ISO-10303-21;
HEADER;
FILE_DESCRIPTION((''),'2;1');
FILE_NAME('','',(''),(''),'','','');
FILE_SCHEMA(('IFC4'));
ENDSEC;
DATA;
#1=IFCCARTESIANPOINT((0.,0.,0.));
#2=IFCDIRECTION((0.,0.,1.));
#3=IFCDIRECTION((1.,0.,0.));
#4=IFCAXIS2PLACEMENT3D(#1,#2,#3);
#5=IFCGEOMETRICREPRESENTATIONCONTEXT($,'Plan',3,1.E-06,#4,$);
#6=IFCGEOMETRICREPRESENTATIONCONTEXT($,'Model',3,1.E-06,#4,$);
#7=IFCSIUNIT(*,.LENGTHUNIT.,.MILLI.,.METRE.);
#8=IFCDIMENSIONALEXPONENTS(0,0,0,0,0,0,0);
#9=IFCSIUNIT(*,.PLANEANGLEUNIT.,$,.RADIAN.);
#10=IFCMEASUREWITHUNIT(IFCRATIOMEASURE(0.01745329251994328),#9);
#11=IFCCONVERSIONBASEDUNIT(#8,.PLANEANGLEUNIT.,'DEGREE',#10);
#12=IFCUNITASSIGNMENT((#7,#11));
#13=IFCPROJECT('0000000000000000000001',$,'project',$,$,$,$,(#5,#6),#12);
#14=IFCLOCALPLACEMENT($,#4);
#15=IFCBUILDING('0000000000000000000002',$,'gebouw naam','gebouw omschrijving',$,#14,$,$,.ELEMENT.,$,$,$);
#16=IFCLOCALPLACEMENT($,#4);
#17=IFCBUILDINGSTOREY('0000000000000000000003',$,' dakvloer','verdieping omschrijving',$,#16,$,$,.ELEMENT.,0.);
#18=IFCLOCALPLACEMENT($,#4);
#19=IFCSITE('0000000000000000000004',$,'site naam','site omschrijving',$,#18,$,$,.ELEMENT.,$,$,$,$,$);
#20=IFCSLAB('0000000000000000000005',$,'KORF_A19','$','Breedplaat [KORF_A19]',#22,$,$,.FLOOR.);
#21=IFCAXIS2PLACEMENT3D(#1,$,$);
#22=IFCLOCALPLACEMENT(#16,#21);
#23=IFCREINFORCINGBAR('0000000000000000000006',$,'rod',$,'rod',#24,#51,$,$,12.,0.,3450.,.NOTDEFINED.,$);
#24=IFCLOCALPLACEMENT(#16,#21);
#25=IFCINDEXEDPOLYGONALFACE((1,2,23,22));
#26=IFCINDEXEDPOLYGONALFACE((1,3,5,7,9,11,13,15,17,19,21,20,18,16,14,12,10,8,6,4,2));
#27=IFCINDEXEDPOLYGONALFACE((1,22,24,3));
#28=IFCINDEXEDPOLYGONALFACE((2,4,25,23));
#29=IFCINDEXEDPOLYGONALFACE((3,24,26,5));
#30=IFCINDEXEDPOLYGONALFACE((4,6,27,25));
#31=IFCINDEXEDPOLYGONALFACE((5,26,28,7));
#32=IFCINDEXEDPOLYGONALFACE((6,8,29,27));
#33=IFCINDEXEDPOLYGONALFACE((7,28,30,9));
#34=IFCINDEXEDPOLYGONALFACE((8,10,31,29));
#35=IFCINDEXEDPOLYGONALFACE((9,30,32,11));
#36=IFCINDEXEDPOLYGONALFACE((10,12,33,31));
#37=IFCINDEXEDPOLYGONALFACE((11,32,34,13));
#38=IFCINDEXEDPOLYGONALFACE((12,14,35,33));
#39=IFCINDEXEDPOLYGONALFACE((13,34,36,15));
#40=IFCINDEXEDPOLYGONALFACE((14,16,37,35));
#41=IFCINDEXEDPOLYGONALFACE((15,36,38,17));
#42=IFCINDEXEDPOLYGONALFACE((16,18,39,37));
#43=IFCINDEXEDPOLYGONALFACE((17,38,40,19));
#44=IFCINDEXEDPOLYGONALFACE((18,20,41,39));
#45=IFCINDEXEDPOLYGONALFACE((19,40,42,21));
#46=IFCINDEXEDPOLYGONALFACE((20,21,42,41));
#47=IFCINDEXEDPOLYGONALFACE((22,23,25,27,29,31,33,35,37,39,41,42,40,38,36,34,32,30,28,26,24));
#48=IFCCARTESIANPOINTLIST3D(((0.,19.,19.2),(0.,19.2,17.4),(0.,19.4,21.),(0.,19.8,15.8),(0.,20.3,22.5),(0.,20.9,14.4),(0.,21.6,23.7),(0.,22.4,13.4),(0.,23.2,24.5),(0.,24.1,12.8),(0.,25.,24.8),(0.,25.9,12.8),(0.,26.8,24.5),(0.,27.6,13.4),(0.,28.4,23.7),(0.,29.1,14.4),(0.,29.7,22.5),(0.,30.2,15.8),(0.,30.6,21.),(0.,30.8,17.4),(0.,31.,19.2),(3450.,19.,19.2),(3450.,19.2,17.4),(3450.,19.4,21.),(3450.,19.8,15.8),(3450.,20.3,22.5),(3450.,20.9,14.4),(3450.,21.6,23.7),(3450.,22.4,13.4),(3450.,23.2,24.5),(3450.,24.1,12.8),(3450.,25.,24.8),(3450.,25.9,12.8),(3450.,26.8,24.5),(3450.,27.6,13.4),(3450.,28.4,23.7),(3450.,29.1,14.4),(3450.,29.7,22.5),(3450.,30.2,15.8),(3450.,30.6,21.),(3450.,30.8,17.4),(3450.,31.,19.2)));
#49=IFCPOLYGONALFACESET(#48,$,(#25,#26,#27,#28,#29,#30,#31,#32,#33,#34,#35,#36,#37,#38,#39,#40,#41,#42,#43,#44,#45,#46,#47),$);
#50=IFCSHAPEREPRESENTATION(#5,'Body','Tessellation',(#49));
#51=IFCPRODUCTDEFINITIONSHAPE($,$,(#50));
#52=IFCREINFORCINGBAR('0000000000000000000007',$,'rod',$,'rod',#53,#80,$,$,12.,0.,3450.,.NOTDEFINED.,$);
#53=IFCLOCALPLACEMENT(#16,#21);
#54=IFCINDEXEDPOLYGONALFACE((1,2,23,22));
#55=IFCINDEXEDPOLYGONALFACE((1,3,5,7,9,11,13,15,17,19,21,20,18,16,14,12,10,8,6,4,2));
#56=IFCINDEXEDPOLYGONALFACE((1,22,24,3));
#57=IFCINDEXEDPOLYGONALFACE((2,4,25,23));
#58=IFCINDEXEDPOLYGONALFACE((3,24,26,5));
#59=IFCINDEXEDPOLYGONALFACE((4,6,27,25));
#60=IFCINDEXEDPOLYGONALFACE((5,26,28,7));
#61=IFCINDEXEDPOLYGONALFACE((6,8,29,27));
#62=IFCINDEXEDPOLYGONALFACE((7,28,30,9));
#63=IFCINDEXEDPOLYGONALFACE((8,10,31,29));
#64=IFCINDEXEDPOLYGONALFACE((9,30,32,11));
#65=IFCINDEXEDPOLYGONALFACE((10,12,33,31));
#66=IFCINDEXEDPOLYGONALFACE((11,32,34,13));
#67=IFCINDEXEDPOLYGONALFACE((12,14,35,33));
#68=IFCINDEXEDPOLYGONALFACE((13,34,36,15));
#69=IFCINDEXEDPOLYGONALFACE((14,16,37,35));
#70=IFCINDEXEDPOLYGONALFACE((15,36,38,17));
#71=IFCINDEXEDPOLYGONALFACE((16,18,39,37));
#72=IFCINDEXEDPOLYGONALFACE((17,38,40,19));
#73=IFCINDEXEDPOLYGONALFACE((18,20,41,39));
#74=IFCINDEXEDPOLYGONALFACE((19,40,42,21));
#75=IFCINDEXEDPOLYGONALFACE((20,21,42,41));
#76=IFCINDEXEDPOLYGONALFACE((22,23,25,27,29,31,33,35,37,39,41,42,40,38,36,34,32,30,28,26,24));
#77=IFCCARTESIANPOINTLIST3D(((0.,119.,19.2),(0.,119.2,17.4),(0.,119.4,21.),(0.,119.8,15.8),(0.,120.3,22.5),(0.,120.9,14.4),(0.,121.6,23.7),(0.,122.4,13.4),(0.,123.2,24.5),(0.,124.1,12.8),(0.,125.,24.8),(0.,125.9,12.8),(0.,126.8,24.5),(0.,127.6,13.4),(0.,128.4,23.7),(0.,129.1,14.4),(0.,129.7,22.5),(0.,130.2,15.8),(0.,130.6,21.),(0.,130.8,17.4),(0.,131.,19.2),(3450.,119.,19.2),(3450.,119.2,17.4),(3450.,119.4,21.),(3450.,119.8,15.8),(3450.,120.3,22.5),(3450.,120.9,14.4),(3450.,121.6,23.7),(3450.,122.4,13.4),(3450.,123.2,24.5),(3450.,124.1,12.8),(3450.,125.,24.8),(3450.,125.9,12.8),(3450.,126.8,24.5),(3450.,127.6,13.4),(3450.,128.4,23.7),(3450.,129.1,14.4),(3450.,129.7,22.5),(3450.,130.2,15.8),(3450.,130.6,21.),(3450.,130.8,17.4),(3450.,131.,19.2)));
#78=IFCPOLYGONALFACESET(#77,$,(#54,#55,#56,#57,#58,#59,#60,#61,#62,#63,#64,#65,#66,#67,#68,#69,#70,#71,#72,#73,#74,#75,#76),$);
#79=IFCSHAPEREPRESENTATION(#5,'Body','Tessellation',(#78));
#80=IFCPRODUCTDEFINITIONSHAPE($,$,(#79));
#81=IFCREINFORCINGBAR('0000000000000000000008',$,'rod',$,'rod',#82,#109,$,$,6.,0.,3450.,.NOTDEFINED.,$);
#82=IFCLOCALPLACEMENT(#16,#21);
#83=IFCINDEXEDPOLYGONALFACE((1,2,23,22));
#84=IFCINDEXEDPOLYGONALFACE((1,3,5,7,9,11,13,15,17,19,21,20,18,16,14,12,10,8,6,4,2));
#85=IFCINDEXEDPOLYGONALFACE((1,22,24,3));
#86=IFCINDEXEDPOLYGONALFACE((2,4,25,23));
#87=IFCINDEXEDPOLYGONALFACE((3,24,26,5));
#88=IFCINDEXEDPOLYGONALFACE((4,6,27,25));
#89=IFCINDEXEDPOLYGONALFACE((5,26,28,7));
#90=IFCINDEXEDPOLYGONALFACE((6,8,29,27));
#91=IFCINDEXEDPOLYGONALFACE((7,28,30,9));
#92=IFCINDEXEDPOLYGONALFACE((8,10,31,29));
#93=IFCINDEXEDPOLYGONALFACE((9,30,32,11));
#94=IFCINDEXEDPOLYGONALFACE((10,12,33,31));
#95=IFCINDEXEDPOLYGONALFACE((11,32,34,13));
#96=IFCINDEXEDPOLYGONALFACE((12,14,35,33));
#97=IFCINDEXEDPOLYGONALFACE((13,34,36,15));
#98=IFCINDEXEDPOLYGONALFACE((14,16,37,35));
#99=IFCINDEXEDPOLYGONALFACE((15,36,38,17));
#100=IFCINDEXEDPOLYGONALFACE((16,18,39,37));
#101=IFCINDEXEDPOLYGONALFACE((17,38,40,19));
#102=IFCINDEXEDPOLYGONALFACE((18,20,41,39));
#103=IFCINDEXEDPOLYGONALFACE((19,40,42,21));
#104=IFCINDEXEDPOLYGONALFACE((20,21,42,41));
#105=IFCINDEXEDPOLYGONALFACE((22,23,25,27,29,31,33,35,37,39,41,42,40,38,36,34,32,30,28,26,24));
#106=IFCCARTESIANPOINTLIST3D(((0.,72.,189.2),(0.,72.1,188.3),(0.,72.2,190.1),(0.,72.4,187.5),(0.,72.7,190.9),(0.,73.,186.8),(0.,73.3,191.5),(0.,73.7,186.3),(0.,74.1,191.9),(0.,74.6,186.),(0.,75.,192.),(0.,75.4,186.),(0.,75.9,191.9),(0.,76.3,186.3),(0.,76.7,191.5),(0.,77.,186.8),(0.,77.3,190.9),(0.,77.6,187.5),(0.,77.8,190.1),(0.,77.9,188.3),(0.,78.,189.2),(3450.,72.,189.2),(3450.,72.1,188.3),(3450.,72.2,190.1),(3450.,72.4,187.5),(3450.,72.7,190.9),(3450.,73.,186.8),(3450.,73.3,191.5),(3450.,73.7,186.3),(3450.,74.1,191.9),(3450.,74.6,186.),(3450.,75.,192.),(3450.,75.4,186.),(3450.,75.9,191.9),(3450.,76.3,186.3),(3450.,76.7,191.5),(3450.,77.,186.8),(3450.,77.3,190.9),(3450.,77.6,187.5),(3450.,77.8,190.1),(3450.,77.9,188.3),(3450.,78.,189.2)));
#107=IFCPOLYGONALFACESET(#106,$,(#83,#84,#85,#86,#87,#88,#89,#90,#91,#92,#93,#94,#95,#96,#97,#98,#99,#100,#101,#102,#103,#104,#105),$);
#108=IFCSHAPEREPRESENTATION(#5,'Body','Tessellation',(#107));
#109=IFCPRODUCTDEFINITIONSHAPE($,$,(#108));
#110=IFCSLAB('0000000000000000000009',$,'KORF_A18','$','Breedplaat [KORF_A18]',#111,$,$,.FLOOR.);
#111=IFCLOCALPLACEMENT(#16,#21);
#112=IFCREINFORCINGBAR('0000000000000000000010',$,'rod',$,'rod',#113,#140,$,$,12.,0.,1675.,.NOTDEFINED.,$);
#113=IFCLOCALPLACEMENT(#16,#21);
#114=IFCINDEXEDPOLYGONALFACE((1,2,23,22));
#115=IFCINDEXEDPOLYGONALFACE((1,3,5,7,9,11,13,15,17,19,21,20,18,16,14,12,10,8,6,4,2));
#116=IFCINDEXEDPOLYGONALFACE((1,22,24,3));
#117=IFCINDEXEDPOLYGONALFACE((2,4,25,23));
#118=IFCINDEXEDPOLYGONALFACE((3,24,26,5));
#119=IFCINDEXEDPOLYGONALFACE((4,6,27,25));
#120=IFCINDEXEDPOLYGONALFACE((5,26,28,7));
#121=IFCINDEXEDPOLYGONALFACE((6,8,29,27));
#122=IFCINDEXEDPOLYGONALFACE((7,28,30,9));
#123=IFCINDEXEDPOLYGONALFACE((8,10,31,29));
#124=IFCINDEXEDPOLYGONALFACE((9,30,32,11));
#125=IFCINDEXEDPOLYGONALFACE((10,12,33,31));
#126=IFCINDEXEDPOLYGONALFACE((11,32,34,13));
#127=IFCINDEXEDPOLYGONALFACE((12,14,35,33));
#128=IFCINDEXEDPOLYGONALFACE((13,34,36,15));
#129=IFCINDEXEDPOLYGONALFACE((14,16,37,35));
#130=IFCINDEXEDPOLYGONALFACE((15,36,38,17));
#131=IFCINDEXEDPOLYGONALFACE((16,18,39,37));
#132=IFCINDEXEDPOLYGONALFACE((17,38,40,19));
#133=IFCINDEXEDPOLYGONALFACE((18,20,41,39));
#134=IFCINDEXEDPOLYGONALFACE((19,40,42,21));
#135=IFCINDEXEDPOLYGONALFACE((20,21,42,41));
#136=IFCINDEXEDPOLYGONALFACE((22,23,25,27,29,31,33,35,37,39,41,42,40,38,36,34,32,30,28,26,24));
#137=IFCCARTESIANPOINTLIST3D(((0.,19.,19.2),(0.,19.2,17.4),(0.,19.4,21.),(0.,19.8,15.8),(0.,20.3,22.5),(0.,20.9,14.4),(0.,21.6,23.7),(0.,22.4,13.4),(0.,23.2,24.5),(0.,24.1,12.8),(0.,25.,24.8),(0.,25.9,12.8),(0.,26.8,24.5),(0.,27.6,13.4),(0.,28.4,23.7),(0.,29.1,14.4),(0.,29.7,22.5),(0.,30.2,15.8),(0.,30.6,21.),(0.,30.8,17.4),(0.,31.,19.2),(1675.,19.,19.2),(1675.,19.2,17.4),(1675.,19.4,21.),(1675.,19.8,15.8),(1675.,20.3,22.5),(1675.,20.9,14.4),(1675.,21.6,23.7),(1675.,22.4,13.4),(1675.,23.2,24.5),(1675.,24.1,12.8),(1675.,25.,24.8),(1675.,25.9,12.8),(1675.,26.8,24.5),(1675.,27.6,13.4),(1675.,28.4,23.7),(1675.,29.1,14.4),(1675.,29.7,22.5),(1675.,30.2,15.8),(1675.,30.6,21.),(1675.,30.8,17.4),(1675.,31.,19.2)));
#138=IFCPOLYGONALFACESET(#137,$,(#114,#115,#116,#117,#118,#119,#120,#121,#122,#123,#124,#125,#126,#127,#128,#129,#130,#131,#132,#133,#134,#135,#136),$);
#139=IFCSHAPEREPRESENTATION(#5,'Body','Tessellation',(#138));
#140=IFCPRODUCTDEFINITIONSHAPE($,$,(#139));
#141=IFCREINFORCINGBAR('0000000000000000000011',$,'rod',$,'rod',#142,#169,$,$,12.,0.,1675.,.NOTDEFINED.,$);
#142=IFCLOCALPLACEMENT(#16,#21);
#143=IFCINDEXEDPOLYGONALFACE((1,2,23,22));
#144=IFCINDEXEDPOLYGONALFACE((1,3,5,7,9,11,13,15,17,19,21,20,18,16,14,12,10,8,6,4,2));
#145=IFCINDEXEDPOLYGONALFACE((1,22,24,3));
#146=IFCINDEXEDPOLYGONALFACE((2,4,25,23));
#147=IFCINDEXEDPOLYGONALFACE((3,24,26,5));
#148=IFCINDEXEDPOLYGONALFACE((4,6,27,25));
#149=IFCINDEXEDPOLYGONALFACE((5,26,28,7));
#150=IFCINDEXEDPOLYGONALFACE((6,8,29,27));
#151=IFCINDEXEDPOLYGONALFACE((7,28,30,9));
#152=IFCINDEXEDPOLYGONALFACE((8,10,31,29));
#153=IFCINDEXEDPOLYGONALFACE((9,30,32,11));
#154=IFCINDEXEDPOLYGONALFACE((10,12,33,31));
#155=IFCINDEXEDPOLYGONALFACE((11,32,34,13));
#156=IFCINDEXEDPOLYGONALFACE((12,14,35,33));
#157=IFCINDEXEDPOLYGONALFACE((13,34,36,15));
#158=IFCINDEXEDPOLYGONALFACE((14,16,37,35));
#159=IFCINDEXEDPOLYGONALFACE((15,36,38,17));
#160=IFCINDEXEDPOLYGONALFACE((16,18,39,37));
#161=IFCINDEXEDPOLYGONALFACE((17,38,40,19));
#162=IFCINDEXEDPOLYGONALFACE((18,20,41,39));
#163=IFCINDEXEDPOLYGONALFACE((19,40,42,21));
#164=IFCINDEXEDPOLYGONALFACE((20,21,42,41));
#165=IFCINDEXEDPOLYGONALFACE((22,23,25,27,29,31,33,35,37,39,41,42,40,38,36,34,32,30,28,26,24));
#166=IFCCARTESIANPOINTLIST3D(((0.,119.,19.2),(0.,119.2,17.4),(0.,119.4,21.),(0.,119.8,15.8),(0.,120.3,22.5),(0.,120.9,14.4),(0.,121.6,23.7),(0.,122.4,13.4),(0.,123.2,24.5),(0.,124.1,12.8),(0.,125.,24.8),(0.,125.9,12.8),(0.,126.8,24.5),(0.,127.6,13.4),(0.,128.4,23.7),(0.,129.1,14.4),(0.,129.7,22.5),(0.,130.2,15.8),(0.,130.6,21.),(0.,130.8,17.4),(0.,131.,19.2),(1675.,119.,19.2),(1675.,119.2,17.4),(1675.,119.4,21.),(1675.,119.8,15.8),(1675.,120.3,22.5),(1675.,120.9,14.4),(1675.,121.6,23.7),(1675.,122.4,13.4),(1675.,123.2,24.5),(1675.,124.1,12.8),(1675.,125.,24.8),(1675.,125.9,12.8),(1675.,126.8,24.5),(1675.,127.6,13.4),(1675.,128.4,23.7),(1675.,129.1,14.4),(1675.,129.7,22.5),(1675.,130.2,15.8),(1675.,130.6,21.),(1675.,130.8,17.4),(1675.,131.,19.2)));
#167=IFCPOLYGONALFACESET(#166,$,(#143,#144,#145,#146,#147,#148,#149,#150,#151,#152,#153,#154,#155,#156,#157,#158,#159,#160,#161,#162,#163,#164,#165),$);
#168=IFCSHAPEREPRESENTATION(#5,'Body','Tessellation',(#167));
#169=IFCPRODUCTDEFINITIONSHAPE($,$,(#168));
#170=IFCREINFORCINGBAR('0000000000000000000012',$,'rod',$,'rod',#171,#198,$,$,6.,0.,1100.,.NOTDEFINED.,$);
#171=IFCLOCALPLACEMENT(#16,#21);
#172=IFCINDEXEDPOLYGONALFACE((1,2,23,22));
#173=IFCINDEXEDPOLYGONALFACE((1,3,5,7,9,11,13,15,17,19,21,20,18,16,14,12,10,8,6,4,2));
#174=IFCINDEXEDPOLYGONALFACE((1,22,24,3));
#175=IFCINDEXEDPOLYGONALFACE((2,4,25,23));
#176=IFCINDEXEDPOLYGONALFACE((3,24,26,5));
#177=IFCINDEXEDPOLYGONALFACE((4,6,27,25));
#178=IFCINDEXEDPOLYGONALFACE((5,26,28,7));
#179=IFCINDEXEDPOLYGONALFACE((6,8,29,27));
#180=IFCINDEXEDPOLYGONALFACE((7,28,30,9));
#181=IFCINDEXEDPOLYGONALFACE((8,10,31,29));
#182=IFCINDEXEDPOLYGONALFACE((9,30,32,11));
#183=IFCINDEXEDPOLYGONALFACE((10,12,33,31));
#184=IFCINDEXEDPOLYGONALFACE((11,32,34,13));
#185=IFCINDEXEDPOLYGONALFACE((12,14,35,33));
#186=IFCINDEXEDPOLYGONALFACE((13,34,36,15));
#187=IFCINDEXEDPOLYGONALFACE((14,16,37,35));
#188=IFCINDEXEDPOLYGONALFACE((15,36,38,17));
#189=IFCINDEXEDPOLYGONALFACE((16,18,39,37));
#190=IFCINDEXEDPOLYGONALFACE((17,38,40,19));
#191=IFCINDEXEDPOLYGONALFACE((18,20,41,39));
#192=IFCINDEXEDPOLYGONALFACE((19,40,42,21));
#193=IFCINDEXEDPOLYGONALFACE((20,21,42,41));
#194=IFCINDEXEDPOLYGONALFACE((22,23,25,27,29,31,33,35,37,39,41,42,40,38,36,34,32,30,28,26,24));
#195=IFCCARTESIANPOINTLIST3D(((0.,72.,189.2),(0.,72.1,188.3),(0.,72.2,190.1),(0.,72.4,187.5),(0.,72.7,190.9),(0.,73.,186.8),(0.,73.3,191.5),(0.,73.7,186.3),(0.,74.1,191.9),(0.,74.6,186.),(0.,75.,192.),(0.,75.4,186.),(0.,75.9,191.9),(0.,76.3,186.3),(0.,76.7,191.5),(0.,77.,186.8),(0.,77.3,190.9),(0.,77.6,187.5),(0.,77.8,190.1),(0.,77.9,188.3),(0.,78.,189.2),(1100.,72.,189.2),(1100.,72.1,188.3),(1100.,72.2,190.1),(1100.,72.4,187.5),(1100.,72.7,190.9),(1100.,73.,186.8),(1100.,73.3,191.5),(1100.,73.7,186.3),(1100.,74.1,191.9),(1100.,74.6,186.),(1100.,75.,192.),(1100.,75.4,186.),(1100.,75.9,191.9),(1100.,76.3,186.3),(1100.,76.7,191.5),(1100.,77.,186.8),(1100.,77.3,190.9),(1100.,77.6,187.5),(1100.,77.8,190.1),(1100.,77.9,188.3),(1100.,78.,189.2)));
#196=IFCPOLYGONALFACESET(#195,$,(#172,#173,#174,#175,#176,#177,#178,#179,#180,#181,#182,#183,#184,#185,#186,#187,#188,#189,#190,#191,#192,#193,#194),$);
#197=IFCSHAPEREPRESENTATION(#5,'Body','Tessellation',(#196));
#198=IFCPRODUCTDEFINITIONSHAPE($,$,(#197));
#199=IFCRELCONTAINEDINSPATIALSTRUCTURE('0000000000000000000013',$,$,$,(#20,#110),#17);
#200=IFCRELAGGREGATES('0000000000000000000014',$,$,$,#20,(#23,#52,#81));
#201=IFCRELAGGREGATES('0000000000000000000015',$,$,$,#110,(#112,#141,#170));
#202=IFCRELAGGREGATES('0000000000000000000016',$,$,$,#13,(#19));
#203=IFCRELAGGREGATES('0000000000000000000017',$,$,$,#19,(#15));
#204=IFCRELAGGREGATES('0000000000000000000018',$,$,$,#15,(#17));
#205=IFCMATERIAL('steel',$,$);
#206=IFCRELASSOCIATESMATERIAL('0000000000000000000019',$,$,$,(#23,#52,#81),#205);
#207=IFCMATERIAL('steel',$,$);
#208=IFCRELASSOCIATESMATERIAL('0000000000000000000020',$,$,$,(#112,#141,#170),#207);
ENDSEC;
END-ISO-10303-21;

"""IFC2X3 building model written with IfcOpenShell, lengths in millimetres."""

from ifc_helpers import new_model, entity, si_unit, converted_unit, frame, origin_with_axes, origin_2d_with_axis, place, context, project, spatial, circle, extrude, material, element, aggregate, save


model = new_model("IFC2X3")

# Units and contexts
plan_context = context("Plan", 3, precision=1e-06, world=origin_with_axes())
model_context = context("Model", 3, precision=1e-06, world=origin_with_axes())
ifc_project = project(units=[si_unit("LENGTHUNIT", "METRE", prefix="MILLI"), converted_unit("PLANEANGLEUNIT", "DEGREE", entity("IfcRatioMeasure", 0.01745329251994328), si_unit("PLANEANGLEUNIT", "RADIAN"), dimensions=[0, 0, 0, 0, 0, 0, 0])], contexts=[plan_context, model_context])

# Site, building, storey
site_placement = place(None, origin_with_axes())
site = spatial("IfcSite", under=ifc_project, at=site_placement, Name="site naam", Description="site omschrijving", CompositionType="ELEMENT")
building_placement = place(None, origin_with_axes())
building = spatial("IfcBuilding", under=site, at=building_placement, Name="gebouw naam", Description="gebouw omschrijving", CompositionType="ELEMENT")
storey_placement = place(None, origin_with_axes())
storey = spatial("IfcBuildingStorey", under=building, at=storey_placement, Name=" dakvloer", Description="verdieping omschrijving", CompositionType="ELEMENT", Elevation=0.0)

# Slabs, reinforcing bars
slab_1_placement = place(None, origin_with_axes())
slab_1 = element("IfcSlab", 1, at=slab_1_placement, inside=storey, Name="KORF_A19", Description="$", ObjectType="Breedplaat [KORF_A19]", PredefinedType="FLOOR")
ifc_material_1 = material(Name="steel")
reinforcing_bar_1_placement = place(slab_1_placement, frame((0.0, 25.0, 18.8), z_axis=(0.0, 0.0, 1.0), x_axis=(1.0, 0.0, 0.0)))
reinforcing_bar_1 = element("IfcReinforcingBar", 2, at=reinforcing_bar_1_placement, material=ifc_material_1, Name="rod", ObjectType="rod", BarLength=3450.0, BarRole="NOTDEFINED", CrossSectionArea=0.0, NominalDiameter=12.0, context=plan_context, shape_type="SweptSolid", body=[
    extrude(circle(Radius=6.0, at=origin_2d_with_axis()), frame((0.0, 0.0, 0.0), z_axis=(1.0, 0.0, 0.0), x_axis=(0.0, 0.0, 1.0)), (0.0, 0.0, 1.0), 3450.0),
])
reinforcing_bar_2_placement = place(slab_1_placement, frame((0.0, 125.0, 18.8), z_axis=(0.0, 0.0, 1.0), x_axis=(1.0, 0.0, 0.0)))
reinforcing_bar_2 = element("IfcReinforcingBar", 3, at=reinforcing_bar_2_placement, material=ifc_material_1, Name="rod", ObjectType="rod", BarLength=3450.0, BarRole="NOTDEFINED", CrossSectionArea=0.0, NominalDiameter=12.0, context=plan_context, shape_type="SweptSolid", body=[
    extrude(circle(Radius=6.0, at=origin_2d_with_axis()), frame((0.0, 0.0, 0.0), z_axis=(1.0, 0.0, 0.0), x_axis=(0.0, 0.0, 1.0)), (0.0, 0.0, 1.0), 3450.0),
])
reinforcing_bar_3_placement = place(slab_1_placement, frame((0.0, 75.0, 189.0), z_axis=(0.0, 0.0, 1.0), x_axis=(1.0, 0.0, 0.0)))
reinforcing_bar_3 = element("IfcReinforcingBar", 4, at=reinforcing_bar_3_placement, material=ifc_material_1, Name="rod", ObjectType="rod", BarLength=3450.0, BarRole="NOTDEFINED", CrossSectionArea=0.0, NominalDiameter=6.0, context=plan_context, shape_type="SweptSolid", body=[
    extrude(circle(Radius=3.0, at=origin_2d_with_axis()), frame((0.0, 0.0, 0.0), z_axis=(1.0, 0.0, 0.0), x_axis=(0.0, 0.0, 1.0)), (0.0, 0.0, 1.0), 3450.0),
])
aggregate(slab_1, [reinforcing_bar_1, reinforcing_bar_2, reinforcing_bar_3])
slab_2_placement = place(None, origin_with_axes())
slab_2 = element("IfcSlab", 5, at=slab_2_placement, inside=storey, Name="KORF_A18", Description="$", ObjectType="Breedplaat [KORF_A18]", PredefinedType="FLOOR")
ifc_material_2 = material(Name="steel")
reinforcing_bar_4_placement = place(slab_2_placement, frame((0.0, 25.0, 18.8), z_axis=(0.0, 0.0, 1.0), x_axis=(1.0, 0.0, 0.0)))
reinforcing_bar_4 = element("IfcReinforcingBar", 6, at=reinforcing_bar_4_placement, material=ifc_material_2, Name="rod", ObjectType="rod", BarLength=1675.0, BarRole="NOTDEFINED", CrossSectionArea=0.0, NominalDiameter=12.0, context=plan_context, shape_type="SweptSolid", body=[
    extrude(circle(Radius=6.0, at=origin_2d_with_axis()), frame((0.0, 0.0, 0.0), z_axis=(1.0, 0.0, 0.0), x_axis=(0.0, 0.0, 1.0)), (0.0, 0.0, 1.0), 1675.0),
])
reinforcing_bar_5_placement = place(slab_2_placement, frame((0.0, 125.0, 18.8), z_axis=(0.0, 0.0, 1.0), x_axis=(1.0, 0.0, 0.0)))
reinforcing_bar_5 = element("IfcReinforcingBar", 7, at=reinforcing_bar_5_placement, material=ifc_material_2, Name="rod", ObjectType="rod", BarLength=1675.0, BarRole="NOTDEFINED", CrossSectionArea=0.0, NominalDiameter=12.0, context=plan_context, shape_type="SweptSolid", body=[
    extrude(circle(Radius=6.0, at=origin_2d_with_axis()), frame((0.0, 0.0, 0.0), z_axis=(1.0, 0.0, 0.0), x_axis=(0.0, 0.0, 1.0)), (0.0, 0.0, 1.0), 1675.0),
])
reinforcing_bar_6_placement = place(slab_2_placement, frame((0.0, 75.0, 189.0), z_axis=(0.0, 0.0, 1.0), x_axis=(1.0, 0.0, 0.0)))
reinforcing_bar_6 = element("IfcReinforcingBar", 8, at=reinforcing_bar_6_placement, material=ifc_material_2, Name="rod", ObjectType="rod", BarLength=1100.0, BarRole="NOTDEFINED", CrossSectionArea=0.0, NominalDiameter=6.0, context=plan_context, shape_type="SweptSolid", body=[
    extrude(circle(Radius=3.0, at=origin_2d_with_axis()), frame((0.0, 0.0, 0.0), z_axis=(1.0, 0.0, 0.0), x_axis=(0.0, 0.0, 1.0)), (0.0, 0.0, 1.0), 1100.0),
])
aggregate(slab_2, [reinforcing_bar_4, reinforcing_bar_5, reinforcing_bar_6])

save(model, "model.ifc")
